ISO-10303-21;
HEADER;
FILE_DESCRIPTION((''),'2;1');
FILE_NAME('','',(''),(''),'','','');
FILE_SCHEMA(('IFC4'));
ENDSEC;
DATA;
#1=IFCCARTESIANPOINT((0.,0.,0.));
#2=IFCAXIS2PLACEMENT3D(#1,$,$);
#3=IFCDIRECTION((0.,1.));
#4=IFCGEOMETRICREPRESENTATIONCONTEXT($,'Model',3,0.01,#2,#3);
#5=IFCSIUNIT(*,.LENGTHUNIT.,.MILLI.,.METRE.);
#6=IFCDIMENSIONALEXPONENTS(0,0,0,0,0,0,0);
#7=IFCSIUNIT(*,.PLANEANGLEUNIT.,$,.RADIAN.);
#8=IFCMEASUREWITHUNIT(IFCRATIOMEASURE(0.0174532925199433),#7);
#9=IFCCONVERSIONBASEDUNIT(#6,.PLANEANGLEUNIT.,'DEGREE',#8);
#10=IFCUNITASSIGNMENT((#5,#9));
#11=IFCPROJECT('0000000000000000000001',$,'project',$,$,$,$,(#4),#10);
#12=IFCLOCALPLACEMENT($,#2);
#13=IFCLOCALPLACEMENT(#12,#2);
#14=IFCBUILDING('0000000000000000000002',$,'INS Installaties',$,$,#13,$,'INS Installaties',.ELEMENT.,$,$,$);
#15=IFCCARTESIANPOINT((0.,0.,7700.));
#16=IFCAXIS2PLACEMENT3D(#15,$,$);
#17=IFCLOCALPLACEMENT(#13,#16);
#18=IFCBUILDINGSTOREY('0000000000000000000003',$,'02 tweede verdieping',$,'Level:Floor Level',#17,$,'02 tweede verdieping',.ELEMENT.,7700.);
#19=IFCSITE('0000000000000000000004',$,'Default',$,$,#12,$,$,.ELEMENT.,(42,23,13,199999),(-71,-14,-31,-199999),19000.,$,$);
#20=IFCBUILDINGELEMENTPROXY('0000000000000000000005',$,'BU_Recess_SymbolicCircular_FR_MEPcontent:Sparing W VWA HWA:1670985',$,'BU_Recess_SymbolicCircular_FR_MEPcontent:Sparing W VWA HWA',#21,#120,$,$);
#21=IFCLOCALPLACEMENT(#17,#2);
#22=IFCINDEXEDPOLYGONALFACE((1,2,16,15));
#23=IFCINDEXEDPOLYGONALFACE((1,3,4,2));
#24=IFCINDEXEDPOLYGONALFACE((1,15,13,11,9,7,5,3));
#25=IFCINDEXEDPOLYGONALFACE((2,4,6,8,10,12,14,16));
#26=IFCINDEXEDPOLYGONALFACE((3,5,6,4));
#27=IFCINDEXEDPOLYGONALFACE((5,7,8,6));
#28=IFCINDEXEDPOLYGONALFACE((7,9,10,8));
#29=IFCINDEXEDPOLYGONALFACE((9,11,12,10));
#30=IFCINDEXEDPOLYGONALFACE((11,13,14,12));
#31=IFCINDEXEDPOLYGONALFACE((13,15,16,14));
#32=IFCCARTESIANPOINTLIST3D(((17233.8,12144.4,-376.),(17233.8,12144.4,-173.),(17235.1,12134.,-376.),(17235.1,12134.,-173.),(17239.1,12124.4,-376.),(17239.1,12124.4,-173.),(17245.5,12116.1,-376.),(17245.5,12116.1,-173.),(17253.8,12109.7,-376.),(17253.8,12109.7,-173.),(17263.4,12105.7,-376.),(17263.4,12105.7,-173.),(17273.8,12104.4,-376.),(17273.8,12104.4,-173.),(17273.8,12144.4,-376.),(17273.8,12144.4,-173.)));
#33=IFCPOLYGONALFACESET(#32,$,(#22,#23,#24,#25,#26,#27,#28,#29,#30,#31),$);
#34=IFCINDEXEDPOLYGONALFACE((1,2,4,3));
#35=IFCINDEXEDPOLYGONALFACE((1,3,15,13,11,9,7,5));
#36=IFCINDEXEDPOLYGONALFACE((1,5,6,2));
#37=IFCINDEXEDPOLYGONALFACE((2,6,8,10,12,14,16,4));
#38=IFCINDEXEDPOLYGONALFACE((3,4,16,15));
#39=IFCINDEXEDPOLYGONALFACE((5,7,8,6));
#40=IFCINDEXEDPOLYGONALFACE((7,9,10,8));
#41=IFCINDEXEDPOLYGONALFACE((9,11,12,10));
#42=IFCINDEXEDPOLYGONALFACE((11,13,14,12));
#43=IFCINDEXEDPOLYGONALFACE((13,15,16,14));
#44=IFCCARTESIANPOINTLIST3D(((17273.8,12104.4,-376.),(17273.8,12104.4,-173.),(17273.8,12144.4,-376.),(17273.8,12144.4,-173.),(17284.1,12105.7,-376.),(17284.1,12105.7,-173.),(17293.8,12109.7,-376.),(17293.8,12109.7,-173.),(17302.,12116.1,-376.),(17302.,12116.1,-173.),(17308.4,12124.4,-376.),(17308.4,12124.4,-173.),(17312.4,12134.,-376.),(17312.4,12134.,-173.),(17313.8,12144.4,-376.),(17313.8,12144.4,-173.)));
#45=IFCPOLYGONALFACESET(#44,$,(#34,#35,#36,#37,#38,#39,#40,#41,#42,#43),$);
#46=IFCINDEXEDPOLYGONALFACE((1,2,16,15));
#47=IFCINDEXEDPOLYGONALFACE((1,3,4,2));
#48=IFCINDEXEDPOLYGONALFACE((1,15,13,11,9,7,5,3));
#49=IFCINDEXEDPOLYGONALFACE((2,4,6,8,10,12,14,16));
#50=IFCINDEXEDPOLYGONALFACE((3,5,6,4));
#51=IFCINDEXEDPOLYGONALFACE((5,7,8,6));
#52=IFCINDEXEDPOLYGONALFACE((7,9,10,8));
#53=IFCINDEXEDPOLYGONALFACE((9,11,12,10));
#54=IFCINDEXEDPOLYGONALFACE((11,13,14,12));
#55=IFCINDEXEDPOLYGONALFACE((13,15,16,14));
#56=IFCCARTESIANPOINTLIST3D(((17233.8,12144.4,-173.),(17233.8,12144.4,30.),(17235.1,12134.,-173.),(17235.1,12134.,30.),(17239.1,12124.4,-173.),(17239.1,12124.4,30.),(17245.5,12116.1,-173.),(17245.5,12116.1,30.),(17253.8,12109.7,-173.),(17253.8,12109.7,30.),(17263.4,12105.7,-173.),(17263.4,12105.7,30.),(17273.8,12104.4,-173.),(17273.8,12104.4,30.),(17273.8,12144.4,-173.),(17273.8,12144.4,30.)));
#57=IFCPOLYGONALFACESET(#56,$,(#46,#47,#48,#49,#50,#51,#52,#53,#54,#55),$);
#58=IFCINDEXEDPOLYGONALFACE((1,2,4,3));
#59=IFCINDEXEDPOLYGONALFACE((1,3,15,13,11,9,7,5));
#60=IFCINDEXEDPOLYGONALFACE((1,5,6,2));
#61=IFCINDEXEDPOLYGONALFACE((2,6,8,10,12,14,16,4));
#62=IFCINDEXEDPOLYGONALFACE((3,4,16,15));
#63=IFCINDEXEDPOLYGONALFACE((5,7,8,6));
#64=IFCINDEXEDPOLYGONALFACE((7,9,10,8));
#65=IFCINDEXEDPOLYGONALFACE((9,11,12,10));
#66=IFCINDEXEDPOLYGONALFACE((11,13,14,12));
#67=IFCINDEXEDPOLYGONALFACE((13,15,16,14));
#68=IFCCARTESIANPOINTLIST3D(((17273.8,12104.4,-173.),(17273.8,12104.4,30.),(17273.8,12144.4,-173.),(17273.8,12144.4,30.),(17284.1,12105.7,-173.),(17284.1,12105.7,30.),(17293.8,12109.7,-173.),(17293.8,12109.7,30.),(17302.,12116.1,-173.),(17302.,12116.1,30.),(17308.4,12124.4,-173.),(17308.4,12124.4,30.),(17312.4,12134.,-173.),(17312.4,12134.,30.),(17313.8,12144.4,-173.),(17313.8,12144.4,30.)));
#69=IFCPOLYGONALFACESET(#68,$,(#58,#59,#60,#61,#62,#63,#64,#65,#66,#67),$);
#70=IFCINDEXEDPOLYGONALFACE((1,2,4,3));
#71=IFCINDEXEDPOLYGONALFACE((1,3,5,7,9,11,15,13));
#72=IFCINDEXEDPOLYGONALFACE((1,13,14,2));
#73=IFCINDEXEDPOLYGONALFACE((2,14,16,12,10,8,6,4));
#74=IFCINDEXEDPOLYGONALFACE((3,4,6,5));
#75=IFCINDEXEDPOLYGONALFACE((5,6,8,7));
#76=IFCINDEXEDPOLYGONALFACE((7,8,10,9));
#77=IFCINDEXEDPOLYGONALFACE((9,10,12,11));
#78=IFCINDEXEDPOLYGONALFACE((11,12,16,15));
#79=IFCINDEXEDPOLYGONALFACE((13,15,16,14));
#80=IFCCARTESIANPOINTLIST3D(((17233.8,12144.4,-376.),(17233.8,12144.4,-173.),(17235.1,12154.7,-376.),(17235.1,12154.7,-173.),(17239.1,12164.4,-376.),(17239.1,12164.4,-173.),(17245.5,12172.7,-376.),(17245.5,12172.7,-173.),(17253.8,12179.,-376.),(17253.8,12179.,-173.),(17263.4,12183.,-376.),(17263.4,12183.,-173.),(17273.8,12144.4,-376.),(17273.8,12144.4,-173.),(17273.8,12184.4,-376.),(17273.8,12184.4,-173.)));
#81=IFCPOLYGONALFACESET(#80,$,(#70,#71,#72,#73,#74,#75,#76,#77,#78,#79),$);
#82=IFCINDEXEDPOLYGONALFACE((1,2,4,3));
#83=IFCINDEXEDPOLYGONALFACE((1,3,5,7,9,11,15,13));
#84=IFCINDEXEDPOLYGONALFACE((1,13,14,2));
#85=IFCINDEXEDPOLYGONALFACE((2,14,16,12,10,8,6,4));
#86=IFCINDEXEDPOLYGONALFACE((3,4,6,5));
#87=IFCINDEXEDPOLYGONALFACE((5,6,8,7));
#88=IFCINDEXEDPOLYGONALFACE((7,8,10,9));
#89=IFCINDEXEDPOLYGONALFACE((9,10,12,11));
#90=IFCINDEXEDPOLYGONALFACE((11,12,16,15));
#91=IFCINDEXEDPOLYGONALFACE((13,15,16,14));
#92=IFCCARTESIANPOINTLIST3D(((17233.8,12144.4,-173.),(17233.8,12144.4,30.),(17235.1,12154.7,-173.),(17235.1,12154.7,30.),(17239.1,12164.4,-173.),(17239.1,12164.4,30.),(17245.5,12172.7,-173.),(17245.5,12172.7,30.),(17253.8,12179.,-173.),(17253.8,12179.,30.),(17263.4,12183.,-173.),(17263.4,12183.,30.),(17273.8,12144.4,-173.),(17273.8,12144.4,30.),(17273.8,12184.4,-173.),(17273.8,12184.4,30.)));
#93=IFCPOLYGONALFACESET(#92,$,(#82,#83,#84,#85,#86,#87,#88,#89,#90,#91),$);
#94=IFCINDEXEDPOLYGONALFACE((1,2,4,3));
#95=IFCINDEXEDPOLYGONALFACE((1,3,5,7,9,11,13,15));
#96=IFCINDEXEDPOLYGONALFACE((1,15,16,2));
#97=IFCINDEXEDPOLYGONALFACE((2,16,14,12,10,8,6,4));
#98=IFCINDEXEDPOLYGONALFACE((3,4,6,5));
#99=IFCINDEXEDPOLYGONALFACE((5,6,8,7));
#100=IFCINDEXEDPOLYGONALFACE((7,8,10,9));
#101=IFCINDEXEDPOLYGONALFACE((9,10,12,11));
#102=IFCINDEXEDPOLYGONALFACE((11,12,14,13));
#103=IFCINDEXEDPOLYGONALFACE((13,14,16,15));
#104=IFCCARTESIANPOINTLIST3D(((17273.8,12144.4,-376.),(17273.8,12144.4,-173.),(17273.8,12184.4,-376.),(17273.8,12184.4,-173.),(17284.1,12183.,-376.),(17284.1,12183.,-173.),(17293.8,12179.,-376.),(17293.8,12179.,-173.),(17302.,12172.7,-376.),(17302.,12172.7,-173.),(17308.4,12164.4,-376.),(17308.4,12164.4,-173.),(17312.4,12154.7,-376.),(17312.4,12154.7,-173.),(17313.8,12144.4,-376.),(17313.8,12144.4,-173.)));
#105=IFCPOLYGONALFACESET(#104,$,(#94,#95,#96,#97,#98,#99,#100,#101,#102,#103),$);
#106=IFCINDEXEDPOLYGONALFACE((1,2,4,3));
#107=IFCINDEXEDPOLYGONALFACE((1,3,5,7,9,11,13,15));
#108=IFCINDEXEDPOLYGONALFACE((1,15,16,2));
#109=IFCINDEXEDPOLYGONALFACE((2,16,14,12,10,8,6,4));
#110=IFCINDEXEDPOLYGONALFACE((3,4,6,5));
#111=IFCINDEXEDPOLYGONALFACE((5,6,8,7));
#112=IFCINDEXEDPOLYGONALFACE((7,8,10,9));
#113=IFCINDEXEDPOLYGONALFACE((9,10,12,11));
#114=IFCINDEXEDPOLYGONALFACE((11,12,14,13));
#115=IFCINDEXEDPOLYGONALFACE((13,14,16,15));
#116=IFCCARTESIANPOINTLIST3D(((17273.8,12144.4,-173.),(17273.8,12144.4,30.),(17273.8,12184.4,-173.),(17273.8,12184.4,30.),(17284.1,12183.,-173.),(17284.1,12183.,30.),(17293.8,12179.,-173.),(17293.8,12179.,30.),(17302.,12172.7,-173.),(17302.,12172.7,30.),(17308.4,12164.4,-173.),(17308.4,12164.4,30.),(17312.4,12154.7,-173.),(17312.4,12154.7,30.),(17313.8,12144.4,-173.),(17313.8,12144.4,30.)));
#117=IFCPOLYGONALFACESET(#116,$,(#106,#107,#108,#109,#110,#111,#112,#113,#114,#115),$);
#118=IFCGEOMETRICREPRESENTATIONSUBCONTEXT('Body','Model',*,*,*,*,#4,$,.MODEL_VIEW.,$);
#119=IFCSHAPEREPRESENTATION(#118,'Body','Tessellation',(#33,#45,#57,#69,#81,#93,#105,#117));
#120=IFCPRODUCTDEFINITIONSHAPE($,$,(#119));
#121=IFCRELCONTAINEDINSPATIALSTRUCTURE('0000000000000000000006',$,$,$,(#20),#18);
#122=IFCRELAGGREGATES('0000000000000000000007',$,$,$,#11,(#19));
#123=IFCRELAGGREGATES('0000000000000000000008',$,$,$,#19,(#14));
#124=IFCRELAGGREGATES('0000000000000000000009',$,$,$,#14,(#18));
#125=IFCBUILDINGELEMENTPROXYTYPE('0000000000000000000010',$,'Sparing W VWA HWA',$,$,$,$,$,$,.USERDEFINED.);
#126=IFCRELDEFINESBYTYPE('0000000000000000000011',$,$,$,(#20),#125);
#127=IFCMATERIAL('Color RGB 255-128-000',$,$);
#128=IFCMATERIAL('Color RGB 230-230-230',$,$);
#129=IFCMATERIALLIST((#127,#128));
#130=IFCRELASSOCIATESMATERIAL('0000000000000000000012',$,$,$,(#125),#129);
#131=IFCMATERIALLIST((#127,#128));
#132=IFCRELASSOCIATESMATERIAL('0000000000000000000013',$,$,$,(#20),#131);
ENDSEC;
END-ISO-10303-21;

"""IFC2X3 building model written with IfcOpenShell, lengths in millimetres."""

from ifc_helpers import new_model, entity, si_unit, converted_unit, direction, frame, frame_2d, origin, place, context, subcontext, project, spatial, polyline, circle_curve, parameter, trimmed, segment, composite_curve, outline, extrude, source, transform, mapped, material, material_list, type_object, type_shapes, element, save


model = new_model("IFC2X3")

# Units and contexts
model_context = context("Model", 3, precision=0.01, world=origin(), true_north=direction((0.0, 1.0)))
body_context = subcontext(model_context, "Body", "Model", "MODEL_VIEW")
ifc_project = project(units=[si_unit("LENGTHUNIT", "METRE", prefix="MILLI"), converted_unit("PLANEANGLEUNIT", "DEGREE", entity("IfcRatioMeasure", 0.0174532925199433), si_unit("PLANEANGLEUNIT", "RADIAN"), dimensions=[0, 0, 0, 0, 0, 0, 0])], contexts=[model_context])

# Site, building, storey
site_placement = place(None, origin())
site = spatial("IfcSite", under=ifc_project, at=site_placement, Name="Default", CompositionType="ELEMENT", RefLatitude=(42, 23, 13, 199999), RefLongitude=(-71, -14, -31, -199999), RefElevation=19000.0)
building_placement = place(site_placement, origin())
building = spatial("IfcBuilding", under=site, at=building_placement, Name="INS Installaties", LongName="INS Installaties", CompositionType="ELEMENT")
storey_placement = place(building_placement, frame((0.0, 0.0, 7700.0)))
storey = spatial("IfcBuildingStorey", under=building, at=storey_placement, Name="02 tweede verdieping", ObjectType="Level:Floor Level", LongName="02 tweede verdieping", CompositionType="ELEMENT", Elevation=7700.0)

# Building element proxy
ifc_material_1 = material(Name="Color RGB 255-128-000")
ifc_material_2 = material(Name="Color RGB 230-230-230")
ifc_material_list_1 = material_list([ifc_material_1, ifc_material_2])
building_element_proxy_type_1 = type_object("IfcBuildingElementProxyType", Name="Sparing W VWA HWA", PredefinedType="USERDEFINED", material=ifc_material_list_1)
shared_shape_1 = source(origin(), body_context, "Body", "SweptSolid", [
    extrude(outline(composite_curve([segment(trimmed(circle_curve(frame_2d((13.3, 13.3), x_axis=(1.0, 0.0)), 40.0), [parameter(180.0)], [parameter(270.0)], True, "PARAMETER"), True, "CONTINUOUS"), segment(polyline([(13.3, -26.7), (13.3, 13.3)]), True, "CONTINUOUS"), segment(polyline([(13.3, 13.3), (-26.7, 13.3)]), True, "CONTINUOUS")], self_intersect=False)), frame((13.3, 13.3, -403.0), z_axis=(0.0, 0.0, 1.0), x_axis=(-1.0, 0.0, 0.0)), (0.0, 0.0, 1.0), 203.0),
    extrude(outline(composite_curve([segment(polyline([(-26.7, -13.3), (13.3, -13.3)]), True, "CONTINUOUS"), segment(polyline([(13.3, -13.3), (13.3, 26.7)]), True, "CONTINUOUS"), segment(trimmed(circle_curve(frame_2d((13.3, -13.3), x_axis=(1.0, 0.0)), 40.0), [parameter(90.0)], [parameter(180.0)], True, "PARAMETER"), True, "CONTINUOUS")], self_intersect=False)), frame((-13.3, 13.3, -403.0)), (0.0, 0.0, 1.0), 203.0),
    extrude(outline(composite_curve([segment(trimmed(circle_curve(frame_2d((13.3, 13.3), x_axis=(1.0, 0.0)), 40.0), [parameter(180.0)], [parameter(270.0)], True, "PARAMETER"), True, "CONTINUOUS"), segment(polyline([(13.3, -26.7), (13.3, 13.3)]), True, "CONTINUOUS"), segment(polyline([(13.3, 13.3), (-26.7, 13.3)]), True, "CONTINUOUS")], self_intersect=False)), frame((13.3, 13.3, -200.0), z_axis=(0.0, 0.0, 1.0), x_axis=(-1.0, 0.0, 0.0)), (0.0, 0.0, 1.0), 203.0),
    extrude(outline(composite_curve([segment(polyline([(-26.7, -13.3), (13.3, -13.3)]), True, "CONTINUOUS"), segment(polyline([(13.3, -13.3), (13.3, 26.7)]), True, "CONTINUOUS"), segment(trimmed(circle_curve(frame_2d((13.3, -13.3), x_axis=(1.0, 0.0)), 40.0), [parameter(90.0)], [parameter(180.0)], True, "PARAMETER"), True, "CONTINUOUS")], self_intersect=False)), frame((-13.3, 13.3, -200.0)), (0.0, 0.0, 1.0), 203.0),
    extrude(outline(composite_curve([segment(polyline([(-26.7, -13.3), (13.3, -13.3)]), True, "CONTINUOUS"), segment(polyline([(13.3, -13.3), (13.3, 26.7)]), True, "CONTINUOUS"), segment(trimmed(circle_curve(frame_2d((13.3, -13.3), x_axis=(1.0, 0.0)), 40.0), [parameter(90.0)], [parameter(180.0)], True, "PARAMETER"), True, "CONTINUOUS")], self_intersect=False)), frame((13.3, -13.3, -403.0), z_axis=(0.0, 0.0, 1.0), x_axis=(-1.0, 0.0, 0.0)), (0.0, 0.0, 1.0), 203.0),
    extrude(outline(composite_curve([segment(polyline([(-26.7, -13.3), (13.3, -13.3)]), True, "CONTINUOUS"), segment(polyline([(13.3, -13.3), (13.3, 26.7)]), True, "CONTINUOUS"), segment(trimmed(circle_curve(frame_2d((13.3, -13.3), x_axis=(1.0, 0.0)), 40.0), [parameter(90.0)], [parameter(180.0)], True, "PARAMETER"), True, "CONTINUOUS")], self_intersect=False)), frame((13.3, -13.3, -200.0), z_axis=(0.0, 0.0, 1.0), x_axis=(-1.0, 0.0, 0.0)), (0.0, 0.0, 1.0), 203.0),
    extrude(outline(composite_curve([segment(trimmed(circle_curve(frame_2d((13.3, 13.3), x_axis=(1.0, 0.0)), 40.0), [parameter(180.0)], [parameter(270.0)], True, "PARAMETER"), True, "CONTINUOUS"), segment(polyline([(13.3, -26.7), (13.3, 13.3)]), True, "CONTINUOUS"), segment(polyline([(13.3, 13.3), (-26.7, 13.3)]), True, "CONTINUOUS")], self_intersect=False)), frame((-13.3, -13.3, -403.0)), (0.0, 0.0, 1.0), 203.0),
    extrude(outline(composite_curve([segment(trimmed(circle_curve(frame_2d((13.3, 13.3), x_axis=(1.0, 0.0)), 40.0), [parameter(180.0)], [parameter(270.0)], True, "PARAMETER"), True, "CONTINUOUS"), segment(polyline([(13.3, -26.7), (13.3, 13.3)]), True, "CONTINUOUS"), segment(polyline([(13.3, 13.3), (-26.7, 13.3)]), True, "CONTINUOUS")], self_intersect=False)), frame((-13.3, -13.3, -200.0)), (0.0, 0.0, 1.0), 203.0),
])
type_shapes(building_element_proxy_type_1, [shared_shape_1])
ifc_material_list_2 = material_list([ifc_material_1, ifc_material_2])
proxy_1_placement = place(storey_placement, frame((17273.8, 12144.4, 27.0), z_axis=(0.0, 0.0, 1.0), x_axis=(-1.0, 0.0, 0.0)))
element("IfcBuildingElementProxy", 1, at=proxy_1_placement, inside=storey, type_object=building_element_proxy_type_1, material=ifc_material_list_2, Name="BU_Recess_SymbolicCircular_FR_MEPcontent:Sparing W VWA HWA:1670985", ObjectType="BU_Recess_SymbolicCircular_FR_MEPcontent:Sparing W VWA HWA", context=body_context, shape_type="MappedRepresentation", body=[
    mapped(shared_shape_1, transform((0.0, 0.0, 0.0), scale=1.0)),
])

save(model, "model.ifc")
